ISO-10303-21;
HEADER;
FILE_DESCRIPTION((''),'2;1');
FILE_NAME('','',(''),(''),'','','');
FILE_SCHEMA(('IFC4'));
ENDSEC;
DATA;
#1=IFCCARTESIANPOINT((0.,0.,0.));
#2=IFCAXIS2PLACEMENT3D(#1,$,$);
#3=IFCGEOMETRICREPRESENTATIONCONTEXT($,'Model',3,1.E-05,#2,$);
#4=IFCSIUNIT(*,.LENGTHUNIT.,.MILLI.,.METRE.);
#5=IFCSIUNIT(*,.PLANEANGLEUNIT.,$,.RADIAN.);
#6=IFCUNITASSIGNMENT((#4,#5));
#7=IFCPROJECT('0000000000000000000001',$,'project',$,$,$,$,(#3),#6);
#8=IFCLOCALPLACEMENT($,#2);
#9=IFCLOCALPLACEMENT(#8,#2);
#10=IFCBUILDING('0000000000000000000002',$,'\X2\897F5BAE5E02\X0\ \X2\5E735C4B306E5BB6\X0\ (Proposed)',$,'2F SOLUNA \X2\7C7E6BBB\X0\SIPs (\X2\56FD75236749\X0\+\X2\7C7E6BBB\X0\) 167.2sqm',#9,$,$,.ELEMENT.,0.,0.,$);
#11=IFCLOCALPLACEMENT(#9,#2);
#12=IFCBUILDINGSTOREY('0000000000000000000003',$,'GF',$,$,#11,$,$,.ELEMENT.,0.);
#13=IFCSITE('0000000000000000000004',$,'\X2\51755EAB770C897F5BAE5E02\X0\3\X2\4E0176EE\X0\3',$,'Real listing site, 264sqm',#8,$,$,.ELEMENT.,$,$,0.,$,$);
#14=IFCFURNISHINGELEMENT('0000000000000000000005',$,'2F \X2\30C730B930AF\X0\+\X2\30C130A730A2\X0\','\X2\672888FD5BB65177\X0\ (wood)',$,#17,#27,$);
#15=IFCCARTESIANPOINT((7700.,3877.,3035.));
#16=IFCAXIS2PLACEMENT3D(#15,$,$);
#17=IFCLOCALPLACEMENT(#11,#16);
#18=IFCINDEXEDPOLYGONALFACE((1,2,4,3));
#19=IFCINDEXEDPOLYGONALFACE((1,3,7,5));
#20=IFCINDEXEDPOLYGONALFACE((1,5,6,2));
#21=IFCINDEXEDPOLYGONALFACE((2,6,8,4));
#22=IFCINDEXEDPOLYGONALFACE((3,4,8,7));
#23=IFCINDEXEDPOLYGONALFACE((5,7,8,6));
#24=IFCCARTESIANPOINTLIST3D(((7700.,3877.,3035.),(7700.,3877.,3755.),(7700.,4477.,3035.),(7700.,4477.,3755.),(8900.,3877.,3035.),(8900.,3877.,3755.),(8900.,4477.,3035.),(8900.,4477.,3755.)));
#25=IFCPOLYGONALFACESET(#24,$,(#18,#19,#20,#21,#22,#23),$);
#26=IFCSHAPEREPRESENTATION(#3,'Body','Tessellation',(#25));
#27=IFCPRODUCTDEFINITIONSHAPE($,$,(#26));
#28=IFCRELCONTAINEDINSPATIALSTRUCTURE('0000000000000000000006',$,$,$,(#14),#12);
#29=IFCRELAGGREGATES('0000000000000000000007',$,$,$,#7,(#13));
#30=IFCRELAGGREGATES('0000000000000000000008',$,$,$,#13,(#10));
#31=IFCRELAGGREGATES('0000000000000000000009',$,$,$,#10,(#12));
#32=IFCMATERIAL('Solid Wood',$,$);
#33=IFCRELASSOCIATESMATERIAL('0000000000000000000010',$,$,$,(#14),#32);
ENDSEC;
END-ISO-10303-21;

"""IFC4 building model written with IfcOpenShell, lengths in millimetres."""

from ifc_helpers import new_model, si_unit, frame, frame_2d, origin, place, context, project, spatial, rectangle, extrude, material, element, save


model = new_model("IFC4")

# Units and contexts
model_context = context("Model", 3, precision=1e-05, world=origin())
ifc_project = project(units=[si_unit("LENGTHUNIT", "METRE", prefix="MILLI"), si_unit("PLANEANGLEUNIT", "RADIAN")], contexts=[model_context])

# Site, building, storey
site_placement = place(None, origin())
site = spatial("IfcSite", under=ifc_project, at=site_placement, Name="兵庫県西宮市3丁目3", ObjectType="Real listing site, 264sqm", CompositionType="ELEMENT", RefElevation=0.0)
building_placement = place(site_placement, origin())
building = spatial("IfcBuilding", under=site, at=building_placement, Name="西宮市 平屋の家 (Proposed)", ObjectType="2F SOLUNA 籾殻SIPs (国産杉+籾殻) 167.2sqm", CompositionType="ELEMENT", ElevationOfRefHeight=0.0, ElevationOfTerrain=0.0)
storey_placement = place(building_placement, origin())
storey = spatial("IfcBuildingStorey", under=building, at=storey_placement, Name="GF", CompositionType="ELEMENT", Elevation=0.0)

# Shared definitions
ifc_material_1 = material(Name="Solid Wood")

# Furnishing element
furnishing_1_placement = place(storey_placement, frame((7700.0, 3877.0, 3035.0)))
element("IfcFurnishingElement", 1, at=furnishing_1_placement, inside=storey, material=ifc_material_1, Name="2F デスク+チェア", Description="木製家具 (wood)", context=model_context, shape_type="SweptSolid", body=[
    extrude(rectangle(XDim=1200.0, YDim=600.0, at=frame_2d((600.0, 300.0))), frame((7700.0, 3877.0, 3035.0)), (0.0, 0.0, 1.0), 720.0),
])

save(model, "model.ifc")
